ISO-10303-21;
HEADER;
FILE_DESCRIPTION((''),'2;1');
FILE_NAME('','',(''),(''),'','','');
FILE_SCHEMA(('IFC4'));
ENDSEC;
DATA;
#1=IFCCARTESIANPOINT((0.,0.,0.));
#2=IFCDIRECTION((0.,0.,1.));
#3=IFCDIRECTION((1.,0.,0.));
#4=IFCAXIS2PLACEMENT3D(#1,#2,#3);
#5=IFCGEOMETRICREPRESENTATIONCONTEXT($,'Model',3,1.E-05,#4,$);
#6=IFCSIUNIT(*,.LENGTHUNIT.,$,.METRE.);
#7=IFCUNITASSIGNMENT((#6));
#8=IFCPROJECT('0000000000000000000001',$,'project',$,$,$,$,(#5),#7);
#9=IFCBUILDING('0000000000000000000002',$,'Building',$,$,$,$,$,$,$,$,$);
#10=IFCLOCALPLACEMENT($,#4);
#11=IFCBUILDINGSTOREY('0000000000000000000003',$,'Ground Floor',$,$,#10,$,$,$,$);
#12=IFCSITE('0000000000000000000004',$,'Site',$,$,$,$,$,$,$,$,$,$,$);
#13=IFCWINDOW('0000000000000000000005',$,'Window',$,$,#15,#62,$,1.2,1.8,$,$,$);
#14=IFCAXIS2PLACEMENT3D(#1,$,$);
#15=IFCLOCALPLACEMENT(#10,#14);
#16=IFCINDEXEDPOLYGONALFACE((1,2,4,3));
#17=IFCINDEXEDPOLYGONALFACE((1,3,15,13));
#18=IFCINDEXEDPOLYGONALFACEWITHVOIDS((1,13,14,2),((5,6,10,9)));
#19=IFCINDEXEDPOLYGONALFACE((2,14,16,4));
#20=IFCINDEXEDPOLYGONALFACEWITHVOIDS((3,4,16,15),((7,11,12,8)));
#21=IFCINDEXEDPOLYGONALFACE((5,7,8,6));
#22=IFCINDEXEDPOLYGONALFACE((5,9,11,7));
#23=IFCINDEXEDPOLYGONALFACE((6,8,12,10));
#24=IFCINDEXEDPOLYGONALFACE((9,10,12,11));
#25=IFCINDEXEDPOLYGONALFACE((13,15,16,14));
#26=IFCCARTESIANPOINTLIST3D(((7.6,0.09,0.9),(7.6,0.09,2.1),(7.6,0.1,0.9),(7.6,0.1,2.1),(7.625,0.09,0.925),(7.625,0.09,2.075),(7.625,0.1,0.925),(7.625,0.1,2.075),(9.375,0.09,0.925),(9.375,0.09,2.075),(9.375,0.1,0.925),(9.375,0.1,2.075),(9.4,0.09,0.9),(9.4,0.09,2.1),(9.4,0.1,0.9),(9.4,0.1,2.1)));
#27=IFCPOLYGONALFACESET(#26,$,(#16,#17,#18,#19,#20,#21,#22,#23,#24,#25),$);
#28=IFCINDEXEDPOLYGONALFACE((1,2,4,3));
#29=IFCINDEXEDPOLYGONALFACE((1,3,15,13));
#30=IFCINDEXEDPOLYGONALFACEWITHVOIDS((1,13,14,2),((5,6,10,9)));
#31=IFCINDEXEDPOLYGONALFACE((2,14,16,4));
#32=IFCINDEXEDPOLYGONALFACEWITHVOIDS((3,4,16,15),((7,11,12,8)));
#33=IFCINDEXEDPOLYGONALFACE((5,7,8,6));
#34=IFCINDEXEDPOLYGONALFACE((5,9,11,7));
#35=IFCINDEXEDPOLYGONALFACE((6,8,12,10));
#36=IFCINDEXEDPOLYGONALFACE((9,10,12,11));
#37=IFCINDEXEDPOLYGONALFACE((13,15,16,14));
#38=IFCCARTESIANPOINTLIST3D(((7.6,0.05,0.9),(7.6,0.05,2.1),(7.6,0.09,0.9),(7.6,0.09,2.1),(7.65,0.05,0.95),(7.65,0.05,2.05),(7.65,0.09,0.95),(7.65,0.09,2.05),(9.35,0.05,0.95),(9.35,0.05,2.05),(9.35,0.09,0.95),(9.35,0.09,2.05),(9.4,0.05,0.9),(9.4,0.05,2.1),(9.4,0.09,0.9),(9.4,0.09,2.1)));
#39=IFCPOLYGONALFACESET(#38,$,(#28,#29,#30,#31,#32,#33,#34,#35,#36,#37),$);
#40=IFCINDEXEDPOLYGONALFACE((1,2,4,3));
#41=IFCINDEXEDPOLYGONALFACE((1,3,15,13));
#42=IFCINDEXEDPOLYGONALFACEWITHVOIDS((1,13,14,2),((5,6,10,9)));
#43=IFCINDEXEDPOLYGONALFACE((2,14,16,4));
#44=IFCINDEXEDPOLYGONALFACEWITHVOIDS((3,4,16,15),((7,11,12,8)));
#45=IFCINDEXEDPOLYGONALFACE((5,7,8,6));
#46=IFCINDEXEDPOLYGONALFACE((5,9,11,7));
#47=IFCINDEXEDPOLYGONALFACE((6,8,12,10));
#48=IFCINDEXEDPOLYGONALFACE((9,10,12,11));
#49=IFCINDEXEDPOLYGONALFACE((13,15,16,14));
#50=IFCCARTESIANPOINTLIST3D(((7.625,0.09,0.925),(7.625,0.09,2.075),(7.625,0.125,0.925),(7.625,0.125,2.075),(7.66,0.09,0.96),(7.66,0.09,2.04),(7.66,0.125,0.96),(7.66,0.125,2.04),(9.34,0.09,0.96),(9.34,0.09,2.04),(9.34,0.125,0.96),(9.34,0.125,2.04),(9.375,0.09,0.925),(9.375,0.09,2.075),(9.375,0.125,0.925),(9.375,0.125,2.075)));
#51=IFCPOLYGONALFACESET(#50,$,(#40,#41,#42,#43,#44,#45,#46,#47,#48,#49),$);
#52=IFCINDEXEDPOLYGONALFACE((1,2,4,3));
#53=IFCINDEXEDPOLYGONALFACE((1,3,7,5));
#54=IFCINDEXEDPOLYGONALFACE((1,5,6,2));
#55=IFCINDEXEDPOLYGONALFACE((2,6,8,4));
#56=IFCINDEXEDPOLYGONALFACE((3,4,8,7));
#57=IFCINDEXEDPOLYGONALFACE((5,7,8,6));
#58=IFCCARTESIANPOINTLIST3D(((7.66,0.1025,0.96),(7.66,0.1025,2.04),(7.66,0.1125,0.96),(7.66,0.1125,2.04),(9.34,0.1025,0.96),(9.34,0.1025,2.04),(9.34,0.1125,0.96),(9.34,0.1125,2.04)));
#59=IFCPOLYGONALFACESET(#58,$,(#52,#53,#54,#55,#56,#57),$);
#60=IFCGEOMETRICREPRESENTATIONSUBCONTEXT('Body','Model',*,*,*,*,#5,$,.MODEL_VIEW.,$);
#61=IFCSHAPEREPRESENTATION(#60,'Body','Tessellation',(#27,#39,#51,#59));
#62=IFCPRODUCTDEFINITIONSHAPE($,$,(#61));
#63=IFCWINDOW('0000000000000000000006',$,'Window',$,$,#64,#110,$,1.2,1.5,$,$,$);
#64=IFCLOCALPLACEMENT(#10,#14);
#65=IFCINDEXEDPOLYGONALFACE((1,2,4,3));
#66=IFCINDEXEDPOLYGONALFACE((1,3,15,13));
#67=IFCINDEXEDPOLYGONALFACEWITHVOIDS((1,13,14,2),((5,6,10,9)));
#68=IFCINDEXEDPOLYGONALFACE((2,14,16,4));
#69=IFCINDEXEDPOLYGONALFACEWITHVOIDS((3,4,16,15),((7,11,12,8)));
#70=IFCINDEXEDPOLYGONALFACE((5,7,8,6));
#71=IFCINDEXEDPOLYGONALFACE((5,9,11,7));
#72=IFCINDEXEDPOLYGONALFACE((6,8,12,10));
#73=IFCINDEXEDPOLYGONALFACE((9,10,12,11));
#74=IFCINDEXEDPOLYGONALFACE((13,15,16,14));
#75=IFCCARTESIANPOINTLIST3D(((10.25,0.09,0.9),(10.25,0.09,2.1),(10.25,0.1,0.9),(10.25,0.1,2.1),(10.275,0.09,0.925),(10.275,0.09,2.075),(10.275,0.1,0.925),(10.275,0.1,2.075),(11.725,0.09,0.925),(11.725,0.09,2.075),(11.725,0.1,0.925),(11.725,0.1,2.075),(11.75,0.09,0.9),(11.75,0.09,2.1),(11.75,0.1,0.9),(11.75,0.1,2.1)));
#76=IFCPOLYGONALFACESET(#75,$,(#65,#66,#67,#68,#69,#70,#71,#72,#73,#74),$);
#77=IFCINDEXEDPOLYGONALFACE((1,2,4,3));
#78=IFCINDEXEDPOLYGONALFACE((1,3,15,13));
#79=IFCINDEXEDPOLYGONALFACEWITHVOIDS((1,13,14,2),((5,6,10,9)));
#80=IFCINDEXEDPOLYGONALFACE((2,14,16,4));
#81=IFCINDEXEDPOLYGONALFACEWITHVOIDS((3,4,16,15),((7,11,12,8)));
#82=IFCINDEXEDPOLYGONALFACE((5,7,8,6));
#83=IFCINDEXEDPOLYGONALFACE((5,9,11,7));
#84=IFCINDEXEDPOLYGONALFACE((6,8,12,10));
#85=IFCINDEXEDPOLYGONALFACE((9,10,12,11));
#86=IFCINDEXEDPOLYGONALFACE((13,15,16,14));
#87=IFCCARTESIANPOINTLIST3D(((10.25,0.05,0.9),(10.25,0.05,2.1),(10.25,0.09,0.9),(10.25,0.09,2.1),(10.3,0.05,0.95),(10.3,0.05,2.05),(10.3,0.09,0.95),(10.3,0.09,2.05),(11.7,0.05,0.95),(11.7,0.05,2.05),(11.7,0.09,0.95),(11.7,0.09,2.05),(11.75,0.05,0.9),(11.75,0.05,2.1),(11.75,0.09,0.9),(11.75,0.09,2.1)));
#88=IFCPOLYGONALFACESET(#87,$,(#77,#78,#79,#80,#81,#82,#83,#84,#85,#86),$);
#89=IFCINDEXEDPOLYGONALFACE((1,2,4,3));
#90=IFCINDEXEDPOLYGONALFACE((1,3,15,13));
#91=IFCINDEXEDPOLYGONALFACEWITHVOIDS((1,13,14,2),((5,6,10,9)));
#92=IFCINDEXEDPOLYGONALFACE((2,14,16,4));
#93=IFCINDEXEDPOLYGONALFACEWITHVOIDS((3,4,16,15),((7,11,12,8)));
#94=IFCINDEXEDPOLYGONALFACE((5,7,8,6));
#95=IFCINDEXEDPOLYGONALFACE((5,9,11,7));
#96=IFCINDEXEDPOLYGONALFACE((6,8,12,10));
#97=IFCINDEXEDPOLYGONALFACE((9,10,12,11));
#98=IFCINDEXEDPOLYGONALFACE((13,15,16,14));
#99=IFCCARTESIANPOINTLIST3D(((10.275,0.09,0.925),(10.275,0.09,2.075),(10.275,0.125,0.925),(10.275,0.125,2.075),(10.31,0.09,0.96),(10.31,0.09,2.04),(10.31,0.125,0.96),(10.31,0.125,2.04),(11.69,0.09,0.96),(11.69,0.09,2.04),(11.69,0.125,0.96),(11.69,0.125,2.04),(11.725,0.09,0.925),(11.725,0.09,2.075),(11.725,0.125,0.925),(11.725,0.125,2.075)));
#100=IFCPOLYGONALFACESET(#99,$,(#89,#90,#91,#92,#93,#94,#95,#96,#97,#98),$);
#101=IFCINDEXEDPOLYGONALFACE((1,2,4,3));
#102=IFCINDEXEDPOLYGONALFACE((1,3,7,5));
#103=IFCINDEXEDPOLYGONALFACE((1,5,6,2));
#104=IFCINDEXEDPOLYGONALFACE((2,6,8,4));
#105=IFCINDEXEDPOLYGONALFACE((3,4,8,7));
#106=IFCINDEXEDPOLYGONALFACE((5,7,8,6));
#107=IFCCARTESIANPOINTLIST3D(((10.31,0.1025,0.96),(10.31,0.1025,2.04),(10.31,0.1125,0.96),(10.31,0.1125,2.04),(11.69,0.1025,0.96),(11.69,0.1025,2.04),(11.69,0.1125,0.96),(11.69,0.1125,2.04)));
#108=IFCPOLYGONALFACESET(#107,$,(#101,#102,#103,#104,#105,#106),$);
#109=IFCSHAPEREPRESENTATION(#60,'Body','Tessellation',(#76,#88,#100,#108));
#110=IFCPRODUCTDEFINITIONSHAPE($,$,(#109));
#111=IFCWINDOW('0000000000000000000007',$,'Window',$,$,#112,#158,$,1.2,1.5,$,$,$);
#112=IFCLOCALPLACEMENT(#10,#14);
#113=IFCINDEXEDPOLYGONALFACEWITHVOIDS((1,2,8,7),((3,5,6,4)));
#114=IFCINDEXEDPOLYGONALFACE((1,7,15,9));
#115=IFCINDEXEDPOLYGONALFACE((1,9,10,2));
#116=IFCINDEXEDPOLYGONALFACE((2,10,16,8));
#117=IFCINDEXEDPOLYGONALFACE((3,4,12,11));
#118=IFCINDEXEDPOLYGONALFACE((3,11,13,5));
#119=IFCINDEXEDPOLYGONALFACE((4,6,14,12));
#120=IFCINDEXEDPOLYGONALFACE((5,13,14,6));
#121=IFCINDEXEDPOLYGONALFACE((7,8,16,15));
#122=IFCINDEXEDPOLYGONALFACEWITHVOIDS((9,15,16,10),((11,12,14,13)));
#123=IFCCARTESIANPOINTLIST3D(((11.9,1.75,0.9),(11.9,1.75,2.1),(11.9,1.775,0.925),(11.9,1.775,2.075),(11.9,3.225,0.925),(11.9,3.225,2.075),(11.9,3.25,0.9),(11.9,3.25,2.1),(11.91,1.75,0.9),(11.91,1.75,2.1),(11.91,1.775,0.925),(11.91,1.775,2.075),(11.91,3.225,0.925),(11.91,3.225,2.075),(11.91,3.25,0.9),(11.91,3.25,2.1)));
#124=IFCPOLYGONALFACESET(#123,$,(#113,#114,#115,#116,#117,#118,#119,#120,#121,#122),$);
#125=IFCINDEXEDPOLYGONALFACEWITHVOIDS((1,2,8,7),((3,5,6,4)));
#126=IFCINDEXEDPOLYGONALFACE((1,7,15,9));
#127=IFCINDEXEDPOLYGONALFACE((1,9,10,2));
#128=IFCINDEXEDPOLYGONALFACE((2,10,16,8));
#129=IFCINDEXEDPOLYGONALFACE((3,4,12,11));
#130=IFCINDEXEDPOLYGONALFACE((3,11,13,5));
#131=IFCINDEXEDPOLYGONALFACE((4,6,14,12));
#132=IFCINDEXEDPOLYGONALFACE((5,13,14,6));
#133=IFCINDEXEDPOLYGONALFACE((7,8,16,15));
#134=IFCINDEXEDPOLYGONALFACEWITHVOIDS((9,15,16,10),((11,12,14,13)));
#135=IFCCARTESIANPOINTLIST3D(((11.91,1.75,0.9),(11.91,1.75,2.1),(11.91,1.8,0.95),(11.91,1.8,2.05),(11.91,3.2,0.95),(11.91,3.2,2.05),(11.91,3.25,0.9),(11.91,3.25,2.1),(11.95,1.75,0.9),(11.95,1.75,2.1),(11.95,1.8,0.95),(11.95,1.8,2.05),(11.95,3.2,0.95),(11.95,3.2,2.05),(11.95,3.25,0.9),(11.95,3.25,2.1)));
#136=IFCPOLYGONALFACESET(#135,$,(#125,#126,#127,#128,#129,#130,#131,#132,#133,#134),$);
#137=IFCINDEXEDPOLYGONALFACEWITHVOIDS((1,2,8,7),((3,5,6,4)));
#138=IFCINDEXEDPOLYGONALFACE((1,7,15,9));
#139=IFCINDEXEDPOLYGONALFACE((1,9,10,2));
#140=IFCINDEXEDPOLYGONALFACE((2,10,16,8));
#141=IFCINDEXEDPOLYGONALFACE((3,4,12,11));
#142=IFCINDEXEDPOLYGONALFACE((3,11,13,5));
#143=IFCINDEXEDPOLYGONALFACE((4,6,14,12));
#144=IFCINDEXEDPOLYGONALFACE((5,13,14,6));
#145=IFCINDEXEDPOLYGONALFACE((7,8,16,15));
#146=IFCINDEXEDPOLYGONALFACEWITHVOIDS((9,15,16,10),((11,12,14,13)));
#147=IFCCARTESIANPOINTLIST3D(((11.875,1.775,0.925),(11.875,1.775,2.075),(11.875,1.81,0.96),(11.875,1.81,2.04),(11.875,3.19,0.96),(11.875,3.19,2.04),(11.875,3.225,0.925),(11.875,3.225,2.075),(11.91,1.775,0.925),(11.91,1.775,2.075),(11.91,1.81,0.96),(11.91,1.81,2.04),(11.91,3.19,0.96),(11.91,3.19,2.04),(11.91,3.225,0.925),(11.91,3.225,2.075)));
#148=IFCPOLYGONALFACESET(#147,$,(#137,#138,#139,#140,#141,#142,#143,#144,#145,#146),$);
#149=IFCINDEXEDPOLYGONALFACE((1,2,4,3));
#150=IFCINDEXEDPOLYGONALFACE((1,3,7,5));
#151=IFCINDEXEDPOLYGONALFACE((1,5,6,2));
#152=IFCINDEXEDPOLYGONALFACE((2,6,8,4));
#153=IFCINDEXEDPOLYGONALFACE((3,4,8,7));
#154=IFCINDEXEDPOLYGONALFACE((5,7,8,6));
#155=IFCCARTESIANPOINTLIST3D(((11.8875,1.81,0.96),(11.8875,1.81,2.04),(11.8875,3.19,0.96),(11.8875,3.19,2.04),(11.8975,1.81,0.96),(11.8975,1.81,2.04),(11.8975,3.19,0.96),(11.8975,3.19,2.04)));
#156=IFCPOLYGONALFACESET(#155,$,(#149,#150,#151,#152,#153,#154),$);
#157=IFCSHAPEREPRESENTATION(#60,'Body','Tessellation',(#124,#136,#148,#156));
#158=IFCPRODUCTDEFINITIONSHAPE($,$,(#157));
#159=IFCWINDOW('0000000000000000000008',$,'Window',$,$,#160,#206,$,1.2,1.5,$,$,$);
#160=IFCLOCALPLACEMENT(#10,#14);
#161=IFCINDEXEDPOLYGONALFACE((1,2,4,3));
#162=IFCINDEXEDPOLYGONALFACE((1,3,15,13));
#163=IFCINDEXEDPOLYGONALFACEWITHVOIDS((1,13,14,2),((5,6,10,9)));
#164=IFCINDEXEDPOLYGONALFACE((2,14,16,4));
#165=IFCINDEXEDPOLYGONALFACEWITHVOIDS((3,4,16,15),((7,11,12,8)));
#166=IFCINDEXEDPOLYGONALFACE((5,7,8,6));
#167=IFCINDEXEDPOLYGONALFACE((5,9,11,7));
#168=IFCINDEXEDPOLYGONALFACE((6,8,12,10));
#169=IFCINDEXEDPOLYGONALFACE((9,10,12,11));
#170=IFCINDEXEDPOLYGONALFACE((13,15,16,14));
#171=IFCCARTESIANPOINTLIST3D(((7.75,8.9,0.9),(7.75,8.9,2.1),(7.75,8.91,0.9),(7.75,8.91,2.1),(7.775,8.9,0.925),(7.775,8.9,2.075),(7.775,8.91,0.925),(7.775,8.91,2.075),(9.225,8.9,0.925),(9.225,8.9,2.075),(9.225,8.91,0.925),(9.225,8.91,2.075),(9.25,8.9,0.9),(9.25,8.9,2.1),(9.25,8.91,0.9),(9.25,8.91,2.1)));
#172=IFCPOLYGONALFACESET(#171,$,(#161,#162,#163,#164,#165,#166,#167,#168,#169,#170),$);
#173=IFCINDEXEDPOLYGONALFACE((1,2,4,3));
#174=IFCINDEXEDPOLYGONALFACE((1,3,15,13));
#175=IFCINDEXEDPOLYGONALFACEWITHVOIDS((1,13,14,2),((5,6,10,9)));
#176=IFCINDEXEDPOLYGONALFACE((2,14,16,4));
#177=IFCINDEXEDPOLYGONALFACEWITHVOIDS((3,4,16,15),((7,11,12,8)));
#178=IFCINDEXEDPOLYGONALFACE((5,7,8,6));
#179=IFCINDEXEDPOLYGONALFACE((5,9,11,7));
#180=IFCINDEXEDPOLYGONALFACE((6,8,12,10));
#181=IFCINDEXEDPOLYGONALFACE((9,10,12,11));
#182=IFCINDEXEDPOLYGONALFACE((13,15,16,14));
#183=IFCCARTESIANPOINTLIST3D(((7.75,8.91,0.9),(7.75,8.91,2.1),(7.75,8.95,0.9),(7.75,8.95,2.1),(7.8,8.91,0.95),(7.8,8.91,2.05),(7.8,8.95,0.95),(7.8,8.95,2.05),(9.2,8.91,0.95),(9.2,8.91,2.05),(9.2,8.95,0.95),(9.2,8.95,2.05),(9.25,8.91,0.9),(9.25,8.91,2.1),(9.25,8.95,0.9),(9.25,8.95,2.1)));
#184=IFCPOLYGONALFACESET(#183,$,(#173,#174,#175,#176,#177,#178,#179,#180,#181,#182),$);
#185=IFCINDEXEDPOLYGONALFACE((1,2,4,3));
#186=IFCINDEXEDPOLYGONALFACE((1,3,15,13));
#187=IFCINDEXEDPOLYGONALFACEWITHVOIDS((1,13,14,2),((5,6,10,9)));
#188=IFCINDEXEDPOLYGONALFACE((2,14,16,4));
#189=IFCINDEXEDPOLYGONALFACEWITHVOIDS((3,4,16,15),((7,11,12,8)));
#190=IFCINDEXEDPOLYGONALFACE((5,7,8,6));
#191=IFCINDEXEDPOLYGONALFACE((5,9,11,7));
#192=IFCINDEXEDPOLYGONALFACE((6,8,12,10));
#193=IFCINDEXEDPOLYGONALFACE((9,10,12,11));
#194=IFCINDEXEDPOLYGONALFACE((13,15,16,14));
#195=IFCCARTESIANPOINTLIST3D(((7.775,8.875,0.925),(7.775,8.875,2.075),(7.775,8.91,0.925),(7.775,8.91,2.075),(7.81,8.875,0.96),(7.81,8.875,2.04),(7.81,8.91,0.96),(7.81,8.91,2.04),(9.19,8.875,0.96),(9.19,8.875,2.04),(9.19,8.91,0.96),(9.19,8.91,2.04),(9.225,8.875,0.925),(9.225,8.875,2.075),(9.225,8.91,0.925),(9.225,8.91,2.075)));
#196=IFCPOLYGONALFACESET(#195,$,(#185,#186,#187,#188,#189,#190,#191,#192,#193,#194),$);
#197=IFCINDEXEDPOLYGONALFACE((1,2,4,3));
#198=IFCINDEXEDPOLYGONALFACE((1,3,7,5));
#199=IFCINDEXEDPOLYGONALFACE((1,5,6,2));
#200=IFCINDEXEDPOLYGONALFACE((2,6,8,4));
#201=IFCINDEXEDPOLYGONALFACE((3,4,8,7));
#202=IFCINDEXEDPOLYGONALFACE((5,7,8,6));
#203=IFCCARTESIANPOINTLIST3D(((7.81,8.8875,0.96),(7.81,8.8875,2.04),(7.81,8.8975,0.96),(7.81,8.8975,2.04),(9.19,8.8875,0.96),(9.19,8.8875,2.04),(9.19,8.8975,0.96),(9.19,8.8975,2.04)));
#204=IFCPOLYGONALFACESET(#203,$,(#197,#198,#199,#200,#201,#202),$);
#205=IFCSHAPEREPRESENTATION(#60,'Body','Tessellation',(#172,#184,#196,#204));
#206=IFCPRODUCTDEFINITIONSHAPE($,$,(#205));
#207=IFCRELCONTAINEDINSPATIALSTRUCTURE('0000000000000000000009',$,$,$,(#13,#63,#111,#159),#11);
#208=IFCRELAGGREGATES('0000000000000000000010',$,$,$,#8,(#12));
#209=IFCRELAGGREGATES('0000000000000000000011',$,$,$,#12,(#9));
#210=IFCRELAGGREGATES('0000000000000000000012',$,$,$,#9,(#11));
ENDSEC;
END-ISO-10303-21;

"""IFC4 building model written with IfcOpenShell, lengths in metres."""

from ifc_helpers import new_model, si_unit, frame, origin_with_axes, place, context, subcontext, project, spatial, line, indexed_curve, outline, extrude, element, save


model = new_model("IFC4")

# Units and contexts
model_context = context("Model", 3, precision=1e-05, world=origin_with_axes())
body_context = subcontext(model_context, "Body", "Model", "MODEL_VIEW")
ifc_project = project(units=[si_unit("LENGTHUNIT", "METRE")], contexts=[model_context])

# Site, building, storey
site = spatial("IfcSite", under=ifc_project, Name="Site")
building = spatial("IfcBuilding", under=site, Name="Building")
storey_placement = place(None, origin_with_axes())
storey = spatial("IfcBuildingStorey", under=building, at=storey_placement, Name="Ground Floor")

# Windows
window_1_placement = place(storey_placement, frame((7.6, 0.0, 0.9), z_axis=(0.0, 0.0, 1.0), x_axis=(1.0, 0.0, 0.0)))
element("IfcWindow", 1, at=window_1_placement, inside=storey, Name="Window", OverallHeight=1.2, OverallWidth=1.8, context=body_context, shape_type="SweptSolid", body=[
    extrude(outline(indexed_curve([(0.0, 0.0), (1.8, 0.0), (1.8, 1.2), (0.0, 1.2)], segments=[line(1, 2, 3, 4, 1)]), holes=[indexed_curve([(0.025, 0.025), (1.775, 0.025), (1.775, 1.175), (0.025, 1.175)], segments=[line(1, 2, 3, 4, 1)])]), frame((0.0, 0.09, 0.0), z_axis=(0.0, -1.0, 0.0), x_axis=(1.0, 0.0, 0.0)), (0.0, 0.0, -1.0), 0.01),
    extrude(outline(indexed_curve([(0.0, 0.0), (1.8, 0.0), (1.8, 1.2), (0.0, 1.2)], segments=[line(1, 2, 3, 4, 1)]), holes=[indexed_curve([(0.05, 0.05), (1.75, 0.05), (1.75, 1.15), (0.05, 1.15)], segments=[line(1, 2, 3, 4, 1)])]), frame((0.0, 0.05, 0.0), z_axis=(0.0, -1.0, 0.0), x_axis=(1.0, 0.0, 0.0)), (0.0, 0.0, -1.0), 0.04),
    extrude(outline(indexed_curve([(0.0, 0.0), (1.75, 0.0), (1.75, 1.15), (0.0, 1.15)], segments=[line(1, 2, 3, 4, 1)]), holes=[indexed_curve([(0.035, 0.035), (1.715, 0.035), (1.715, 1.115), (0.035, 1.115)], segments=[line(1, 2, 3, 4, 1)])]), frame((0.025, 0.09, 0.025), z_axis=(0.0, -1.0, 0.0), x_axis=(1.0, 0.0, 0.0)), (0.0, 0.0, -1.0), 0.035),
    extrude(outline(indexed_curve([(0.035, 0.035), (1.715, 0.035), (1.715, 1.115), (0.035, 1.115)], segments=[line(1, 2, 3, 4, 1)])), frame((0.025, 0.1025, 0.025), z_axis=(0.0, -1.0, 0.0), x_axis=(1.0, 0.0, 0.0)), (0.0, 0.0, -1.0), 0.01),
])
for number, where, z_axis, x_axis, name in (
    (2, (10.25, 0.0, 0.9), (0.0, 0.0, 1.0), (1.0, 0.0, 0.0), "Window"),
    (3, (12.0, 1.75, 0.9), (0.0, 0.0, 1.0), (0.0, 1.0, 0.0), "Window"),
    (4, (9.25, 9.0, 0.9), (0.0, 0.0, 1.0), (-1.0, 0.0, 0.0), "Window"),
):
    element("IfcWindow", number, at=place(storey_placement, frame(where, z_axis=z_axis, x_axis=x_axis)), inside=storey, Name=name, OverallHeight=1.2, OverallWidth=1.5, context=body_context, shape_type="SweptSolid", body=[
        extrude(outline(indexed_curve([(0.0, 0.0), (1.5, 0.0), (1.5, 1.2), (0.0, 1.2)], segments=[line(1, 2, 3, 4, 1)]), holes=[indexed_curve([(0.025, 0.025), (1.475, 0.025), (1.475, 1.175), (0.025, 1.175)], segments=[line(1, 2, 3, 4, 1)])]), frame((0.0, 0.09, 0.0), z_axis=(0.0, -1.0, 0.0), x_axis=(1.0, 0.0, 0.0)), (0.0, 0.0, -1.0), 0.01),
        extrude(outline(indexed_curve([(0.0, 0.0), (1.5, 0.0), (1.5, 1.2), (0.0, 1.2)], segments=[line(1, 2, 3, 4, 1)]), holes=[indexed_curve([(0.05, 0.05), (1.45, 0.05), (1.45, 1.15), (0.05, 1.15)], segments=[line(1, 2, 3, 4, 1)])]), frame((0.0, 0.05, 0.0), z_axis=(0.0, -1.0, 0.0), x_axis=(1.0, 0.0, 0.0)), (0.0, 0.0, -1.0), 0.04),
        extrude(outline(indexed_curve([(0.0, 0.0), (1.45, 0.0), (1.45, 1.15), (0.0, 1.15)], segments=[line(1, 2, 3, 4, 1)]), holes=[indexed_curve([(0.035, 0.035), (1.415, 0.035), (1.415, 1.115), (0.035, 1.115)], segments=[line(1, 2, 3, 4, 1)])]), frame((0.025, 0.09, 0.025), z_axis=(0.0, -1.0, 0.0), x_axis=(1.0, 0.0, 0.0)), (0.0, 0.0, -1.0), 0.035),
        extrude(outline(indexed_curve([(0.035, 0.035), (1.415, 0.035), (1.415, 1.115), (0.035, 1.115)], segments=[line(1, 2, 3, 4, 1)])), frame((0.025, 0.1025, 0.025), z_axis=(0.0, -1.0, 0.0), x_axis=(1.0, 0.0, 0.0)), (0.0, 0.0, -1.0), 0.01),
    ])

save(model, "model.ifc")
